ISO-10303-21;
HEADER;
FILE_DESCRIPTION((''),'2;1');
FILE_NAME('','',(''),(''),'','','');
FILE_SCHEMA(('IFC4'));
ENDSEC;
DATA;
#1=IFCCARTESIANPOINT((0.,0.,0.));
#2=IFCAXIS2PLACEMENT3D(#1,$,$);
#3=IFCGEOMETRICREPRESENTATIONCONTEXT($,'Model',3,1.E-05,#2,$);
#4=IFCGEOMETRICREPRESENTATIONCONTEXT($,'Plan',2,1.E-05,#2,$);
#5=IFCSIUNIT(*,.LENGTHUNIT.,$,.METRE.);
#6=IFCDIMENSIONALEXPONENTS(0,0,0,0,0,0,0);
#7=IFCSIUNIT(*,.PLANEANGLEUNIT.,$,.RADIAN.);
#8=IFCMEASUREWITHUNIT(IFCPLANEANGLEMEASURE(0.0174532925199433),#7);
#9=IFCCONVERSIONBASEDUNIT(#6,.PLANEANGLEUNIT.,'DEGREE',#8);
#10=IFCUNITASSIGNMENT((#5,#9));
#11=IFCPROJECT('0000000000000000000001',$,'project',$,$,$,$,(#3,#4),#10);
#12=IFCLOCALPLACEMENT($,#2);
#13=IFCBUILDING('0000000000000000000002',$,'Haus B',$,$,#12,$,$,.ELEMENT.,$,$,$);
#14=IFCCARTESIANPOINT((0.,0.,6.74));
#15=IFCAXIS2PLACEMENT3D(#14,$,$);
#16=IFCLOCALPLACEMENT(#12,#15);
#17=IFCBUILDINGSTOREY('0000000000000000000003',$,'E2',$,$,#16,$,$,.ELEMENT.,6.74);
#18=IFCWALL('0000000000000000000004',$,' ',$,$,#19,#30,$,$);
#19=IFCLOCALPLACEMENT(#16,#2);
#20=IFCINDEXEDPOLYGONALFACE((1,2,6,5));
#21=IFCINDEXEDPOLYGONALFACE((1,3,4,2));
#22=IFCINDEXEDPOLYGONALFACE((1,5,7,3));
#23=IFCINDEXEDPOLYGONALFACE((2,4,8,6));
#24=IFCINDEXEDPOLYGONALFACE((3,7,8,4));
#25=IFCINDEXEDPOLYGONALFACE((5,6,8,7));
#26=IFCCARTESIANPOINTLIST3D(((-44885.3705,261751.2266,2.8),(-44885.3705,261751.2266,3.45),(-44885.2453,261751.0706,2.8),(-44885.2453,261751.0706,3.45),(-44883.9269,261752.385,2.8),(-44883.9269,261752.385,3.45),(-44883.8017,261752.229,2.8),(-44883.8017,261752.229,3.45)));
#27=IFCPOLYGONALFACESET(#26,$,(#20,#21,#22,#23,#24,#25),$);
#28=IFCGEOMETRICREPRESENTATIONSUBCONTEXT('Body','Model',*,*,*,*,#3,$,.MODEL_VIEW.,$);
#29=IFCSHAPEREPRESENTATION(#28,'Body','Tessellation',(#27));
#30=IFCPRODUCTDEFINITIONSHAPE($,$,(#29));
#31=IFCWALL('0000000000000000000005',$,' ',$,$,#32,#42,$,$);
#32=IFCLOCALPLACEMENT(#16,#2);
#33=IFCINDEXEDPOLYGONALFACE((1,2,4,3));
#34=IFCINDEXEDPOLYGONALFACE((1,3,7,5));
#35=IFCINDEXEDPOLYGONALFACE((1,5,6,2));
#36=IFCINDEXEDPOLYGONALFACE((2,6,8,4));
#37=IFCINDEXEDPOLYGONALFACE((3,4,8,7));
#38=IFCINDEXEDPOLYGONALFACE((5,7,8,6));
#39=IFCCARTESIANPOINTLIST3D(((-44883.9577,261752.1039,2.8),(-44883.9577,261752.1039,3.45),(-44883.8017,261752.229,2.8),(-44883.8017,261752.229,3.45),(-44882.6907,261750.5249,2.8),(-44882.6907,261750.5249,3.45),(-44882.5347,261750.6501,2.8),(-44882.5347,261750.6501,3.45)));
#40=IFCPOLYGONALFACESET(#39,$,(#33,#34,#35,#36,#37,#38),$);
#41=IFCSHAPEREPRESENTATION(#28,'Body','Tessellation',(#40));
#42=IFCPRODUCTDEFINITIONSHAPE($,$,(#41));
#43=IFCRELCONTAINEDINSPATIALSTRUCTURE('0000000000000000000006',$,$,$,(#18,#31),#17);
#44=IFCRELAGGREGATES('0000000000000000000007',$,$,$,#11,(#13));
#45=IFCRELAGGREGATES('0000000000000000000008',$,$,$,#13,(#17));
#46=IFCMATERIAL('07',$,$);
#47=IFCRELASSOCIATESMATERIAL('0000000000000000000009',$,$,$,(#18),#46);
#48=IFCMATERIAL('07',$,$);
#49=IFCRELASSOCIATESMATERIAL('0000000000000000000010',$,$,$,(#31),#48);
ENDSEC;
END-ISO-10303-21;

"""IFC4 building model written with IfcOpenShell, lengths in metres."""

from ifc_helpers import new_model, entity, si_unit, converted_unit, frame, frame_2d, origin, origin_with_axes, place, context, subcontext, project, spatial, rectangle, extrude, material, element, save


model = new_model("IFC4")

# Units and contexts
model_context = context("Model", 3, precision=1e-05, world=origin())
plan_context = context("Plan", 2, precision=1e-05, world=origin())
body_context = subcontext(model_context, "Body", "Model", "MODEL_VIEW")
ifc_project = project(units=[si_unit("LENGTHUNIT", "METRE"), converted_unit("PLANEANGLEUNIT", "DEGREE", entity("IfcPlaneAngleMeasure", 0.0174532925199433), si_unit("PLANEANGLEUNIT", "RADIAN"), dimensions=[0, 0, 0, 0, 0, 0, 0])], contexts=[model_context, plan_context])

# Building, storey
building_placement = place(None, origin())
building = spatial("IfcBuilding", under=ifc_project, at=building_placement, Name="Haus B", CompositionType="ELEMENT")
storey_placement = place(building_placement, frame((0.0, 0.0, 6.74)))
storey = spatial("IfcBuildingStorey", under=building, at=storey_placement, Name="E2", CompositionType="ELEMENT", Elevation=6.74)

# Walls
ifc_material_1 = material(Name="07")
wall_1_placement = place(storey_placement, frame((-44885.2453, 261751.0706, 2.8), z_axis=(0.0, 0.0, 1.0), x_axis=(0.779935, 0.625861, 0.0)))
element("IfcWall", 1, at=wall_1_placement, inside=storey, material=ifc_material_1, Name=" ", context=body_context, shape_type="SweptSolid", body=[
    extrude(rectangle(XDim=1.8509, YDim=0.2, at=frame_2d((0.9255, 0.1), x_axis=(1.0, 0.0))), origin_with_axes(), (0.0, 0.0, 1.0), 0.65),
])
ifc_material_2 = material(Name="07")
wall_2_placement = place(storey_placement, frame((-44883.9577, 261752.1039, 2.8), z_axis=(0.0, 0.0, 1.0), x_axis=(0.625861, -0.779935, 0.0)))
element("IfcWall", 2, at=wall_2_placement, inside=storey, material=ifc_material_2, Name=" ", context=body_context, shape_type="SweptSolid", body=[
    extrude(rectangle(XDim=2.0245, YDim=0.2, at=frame_2d((1.0122, 0.1), x_axis=(1.0, 0.0))), origin_with_axes(), (0.0, 0.0, 1.0), 0.65),
])

save(model, "model.ifc")
